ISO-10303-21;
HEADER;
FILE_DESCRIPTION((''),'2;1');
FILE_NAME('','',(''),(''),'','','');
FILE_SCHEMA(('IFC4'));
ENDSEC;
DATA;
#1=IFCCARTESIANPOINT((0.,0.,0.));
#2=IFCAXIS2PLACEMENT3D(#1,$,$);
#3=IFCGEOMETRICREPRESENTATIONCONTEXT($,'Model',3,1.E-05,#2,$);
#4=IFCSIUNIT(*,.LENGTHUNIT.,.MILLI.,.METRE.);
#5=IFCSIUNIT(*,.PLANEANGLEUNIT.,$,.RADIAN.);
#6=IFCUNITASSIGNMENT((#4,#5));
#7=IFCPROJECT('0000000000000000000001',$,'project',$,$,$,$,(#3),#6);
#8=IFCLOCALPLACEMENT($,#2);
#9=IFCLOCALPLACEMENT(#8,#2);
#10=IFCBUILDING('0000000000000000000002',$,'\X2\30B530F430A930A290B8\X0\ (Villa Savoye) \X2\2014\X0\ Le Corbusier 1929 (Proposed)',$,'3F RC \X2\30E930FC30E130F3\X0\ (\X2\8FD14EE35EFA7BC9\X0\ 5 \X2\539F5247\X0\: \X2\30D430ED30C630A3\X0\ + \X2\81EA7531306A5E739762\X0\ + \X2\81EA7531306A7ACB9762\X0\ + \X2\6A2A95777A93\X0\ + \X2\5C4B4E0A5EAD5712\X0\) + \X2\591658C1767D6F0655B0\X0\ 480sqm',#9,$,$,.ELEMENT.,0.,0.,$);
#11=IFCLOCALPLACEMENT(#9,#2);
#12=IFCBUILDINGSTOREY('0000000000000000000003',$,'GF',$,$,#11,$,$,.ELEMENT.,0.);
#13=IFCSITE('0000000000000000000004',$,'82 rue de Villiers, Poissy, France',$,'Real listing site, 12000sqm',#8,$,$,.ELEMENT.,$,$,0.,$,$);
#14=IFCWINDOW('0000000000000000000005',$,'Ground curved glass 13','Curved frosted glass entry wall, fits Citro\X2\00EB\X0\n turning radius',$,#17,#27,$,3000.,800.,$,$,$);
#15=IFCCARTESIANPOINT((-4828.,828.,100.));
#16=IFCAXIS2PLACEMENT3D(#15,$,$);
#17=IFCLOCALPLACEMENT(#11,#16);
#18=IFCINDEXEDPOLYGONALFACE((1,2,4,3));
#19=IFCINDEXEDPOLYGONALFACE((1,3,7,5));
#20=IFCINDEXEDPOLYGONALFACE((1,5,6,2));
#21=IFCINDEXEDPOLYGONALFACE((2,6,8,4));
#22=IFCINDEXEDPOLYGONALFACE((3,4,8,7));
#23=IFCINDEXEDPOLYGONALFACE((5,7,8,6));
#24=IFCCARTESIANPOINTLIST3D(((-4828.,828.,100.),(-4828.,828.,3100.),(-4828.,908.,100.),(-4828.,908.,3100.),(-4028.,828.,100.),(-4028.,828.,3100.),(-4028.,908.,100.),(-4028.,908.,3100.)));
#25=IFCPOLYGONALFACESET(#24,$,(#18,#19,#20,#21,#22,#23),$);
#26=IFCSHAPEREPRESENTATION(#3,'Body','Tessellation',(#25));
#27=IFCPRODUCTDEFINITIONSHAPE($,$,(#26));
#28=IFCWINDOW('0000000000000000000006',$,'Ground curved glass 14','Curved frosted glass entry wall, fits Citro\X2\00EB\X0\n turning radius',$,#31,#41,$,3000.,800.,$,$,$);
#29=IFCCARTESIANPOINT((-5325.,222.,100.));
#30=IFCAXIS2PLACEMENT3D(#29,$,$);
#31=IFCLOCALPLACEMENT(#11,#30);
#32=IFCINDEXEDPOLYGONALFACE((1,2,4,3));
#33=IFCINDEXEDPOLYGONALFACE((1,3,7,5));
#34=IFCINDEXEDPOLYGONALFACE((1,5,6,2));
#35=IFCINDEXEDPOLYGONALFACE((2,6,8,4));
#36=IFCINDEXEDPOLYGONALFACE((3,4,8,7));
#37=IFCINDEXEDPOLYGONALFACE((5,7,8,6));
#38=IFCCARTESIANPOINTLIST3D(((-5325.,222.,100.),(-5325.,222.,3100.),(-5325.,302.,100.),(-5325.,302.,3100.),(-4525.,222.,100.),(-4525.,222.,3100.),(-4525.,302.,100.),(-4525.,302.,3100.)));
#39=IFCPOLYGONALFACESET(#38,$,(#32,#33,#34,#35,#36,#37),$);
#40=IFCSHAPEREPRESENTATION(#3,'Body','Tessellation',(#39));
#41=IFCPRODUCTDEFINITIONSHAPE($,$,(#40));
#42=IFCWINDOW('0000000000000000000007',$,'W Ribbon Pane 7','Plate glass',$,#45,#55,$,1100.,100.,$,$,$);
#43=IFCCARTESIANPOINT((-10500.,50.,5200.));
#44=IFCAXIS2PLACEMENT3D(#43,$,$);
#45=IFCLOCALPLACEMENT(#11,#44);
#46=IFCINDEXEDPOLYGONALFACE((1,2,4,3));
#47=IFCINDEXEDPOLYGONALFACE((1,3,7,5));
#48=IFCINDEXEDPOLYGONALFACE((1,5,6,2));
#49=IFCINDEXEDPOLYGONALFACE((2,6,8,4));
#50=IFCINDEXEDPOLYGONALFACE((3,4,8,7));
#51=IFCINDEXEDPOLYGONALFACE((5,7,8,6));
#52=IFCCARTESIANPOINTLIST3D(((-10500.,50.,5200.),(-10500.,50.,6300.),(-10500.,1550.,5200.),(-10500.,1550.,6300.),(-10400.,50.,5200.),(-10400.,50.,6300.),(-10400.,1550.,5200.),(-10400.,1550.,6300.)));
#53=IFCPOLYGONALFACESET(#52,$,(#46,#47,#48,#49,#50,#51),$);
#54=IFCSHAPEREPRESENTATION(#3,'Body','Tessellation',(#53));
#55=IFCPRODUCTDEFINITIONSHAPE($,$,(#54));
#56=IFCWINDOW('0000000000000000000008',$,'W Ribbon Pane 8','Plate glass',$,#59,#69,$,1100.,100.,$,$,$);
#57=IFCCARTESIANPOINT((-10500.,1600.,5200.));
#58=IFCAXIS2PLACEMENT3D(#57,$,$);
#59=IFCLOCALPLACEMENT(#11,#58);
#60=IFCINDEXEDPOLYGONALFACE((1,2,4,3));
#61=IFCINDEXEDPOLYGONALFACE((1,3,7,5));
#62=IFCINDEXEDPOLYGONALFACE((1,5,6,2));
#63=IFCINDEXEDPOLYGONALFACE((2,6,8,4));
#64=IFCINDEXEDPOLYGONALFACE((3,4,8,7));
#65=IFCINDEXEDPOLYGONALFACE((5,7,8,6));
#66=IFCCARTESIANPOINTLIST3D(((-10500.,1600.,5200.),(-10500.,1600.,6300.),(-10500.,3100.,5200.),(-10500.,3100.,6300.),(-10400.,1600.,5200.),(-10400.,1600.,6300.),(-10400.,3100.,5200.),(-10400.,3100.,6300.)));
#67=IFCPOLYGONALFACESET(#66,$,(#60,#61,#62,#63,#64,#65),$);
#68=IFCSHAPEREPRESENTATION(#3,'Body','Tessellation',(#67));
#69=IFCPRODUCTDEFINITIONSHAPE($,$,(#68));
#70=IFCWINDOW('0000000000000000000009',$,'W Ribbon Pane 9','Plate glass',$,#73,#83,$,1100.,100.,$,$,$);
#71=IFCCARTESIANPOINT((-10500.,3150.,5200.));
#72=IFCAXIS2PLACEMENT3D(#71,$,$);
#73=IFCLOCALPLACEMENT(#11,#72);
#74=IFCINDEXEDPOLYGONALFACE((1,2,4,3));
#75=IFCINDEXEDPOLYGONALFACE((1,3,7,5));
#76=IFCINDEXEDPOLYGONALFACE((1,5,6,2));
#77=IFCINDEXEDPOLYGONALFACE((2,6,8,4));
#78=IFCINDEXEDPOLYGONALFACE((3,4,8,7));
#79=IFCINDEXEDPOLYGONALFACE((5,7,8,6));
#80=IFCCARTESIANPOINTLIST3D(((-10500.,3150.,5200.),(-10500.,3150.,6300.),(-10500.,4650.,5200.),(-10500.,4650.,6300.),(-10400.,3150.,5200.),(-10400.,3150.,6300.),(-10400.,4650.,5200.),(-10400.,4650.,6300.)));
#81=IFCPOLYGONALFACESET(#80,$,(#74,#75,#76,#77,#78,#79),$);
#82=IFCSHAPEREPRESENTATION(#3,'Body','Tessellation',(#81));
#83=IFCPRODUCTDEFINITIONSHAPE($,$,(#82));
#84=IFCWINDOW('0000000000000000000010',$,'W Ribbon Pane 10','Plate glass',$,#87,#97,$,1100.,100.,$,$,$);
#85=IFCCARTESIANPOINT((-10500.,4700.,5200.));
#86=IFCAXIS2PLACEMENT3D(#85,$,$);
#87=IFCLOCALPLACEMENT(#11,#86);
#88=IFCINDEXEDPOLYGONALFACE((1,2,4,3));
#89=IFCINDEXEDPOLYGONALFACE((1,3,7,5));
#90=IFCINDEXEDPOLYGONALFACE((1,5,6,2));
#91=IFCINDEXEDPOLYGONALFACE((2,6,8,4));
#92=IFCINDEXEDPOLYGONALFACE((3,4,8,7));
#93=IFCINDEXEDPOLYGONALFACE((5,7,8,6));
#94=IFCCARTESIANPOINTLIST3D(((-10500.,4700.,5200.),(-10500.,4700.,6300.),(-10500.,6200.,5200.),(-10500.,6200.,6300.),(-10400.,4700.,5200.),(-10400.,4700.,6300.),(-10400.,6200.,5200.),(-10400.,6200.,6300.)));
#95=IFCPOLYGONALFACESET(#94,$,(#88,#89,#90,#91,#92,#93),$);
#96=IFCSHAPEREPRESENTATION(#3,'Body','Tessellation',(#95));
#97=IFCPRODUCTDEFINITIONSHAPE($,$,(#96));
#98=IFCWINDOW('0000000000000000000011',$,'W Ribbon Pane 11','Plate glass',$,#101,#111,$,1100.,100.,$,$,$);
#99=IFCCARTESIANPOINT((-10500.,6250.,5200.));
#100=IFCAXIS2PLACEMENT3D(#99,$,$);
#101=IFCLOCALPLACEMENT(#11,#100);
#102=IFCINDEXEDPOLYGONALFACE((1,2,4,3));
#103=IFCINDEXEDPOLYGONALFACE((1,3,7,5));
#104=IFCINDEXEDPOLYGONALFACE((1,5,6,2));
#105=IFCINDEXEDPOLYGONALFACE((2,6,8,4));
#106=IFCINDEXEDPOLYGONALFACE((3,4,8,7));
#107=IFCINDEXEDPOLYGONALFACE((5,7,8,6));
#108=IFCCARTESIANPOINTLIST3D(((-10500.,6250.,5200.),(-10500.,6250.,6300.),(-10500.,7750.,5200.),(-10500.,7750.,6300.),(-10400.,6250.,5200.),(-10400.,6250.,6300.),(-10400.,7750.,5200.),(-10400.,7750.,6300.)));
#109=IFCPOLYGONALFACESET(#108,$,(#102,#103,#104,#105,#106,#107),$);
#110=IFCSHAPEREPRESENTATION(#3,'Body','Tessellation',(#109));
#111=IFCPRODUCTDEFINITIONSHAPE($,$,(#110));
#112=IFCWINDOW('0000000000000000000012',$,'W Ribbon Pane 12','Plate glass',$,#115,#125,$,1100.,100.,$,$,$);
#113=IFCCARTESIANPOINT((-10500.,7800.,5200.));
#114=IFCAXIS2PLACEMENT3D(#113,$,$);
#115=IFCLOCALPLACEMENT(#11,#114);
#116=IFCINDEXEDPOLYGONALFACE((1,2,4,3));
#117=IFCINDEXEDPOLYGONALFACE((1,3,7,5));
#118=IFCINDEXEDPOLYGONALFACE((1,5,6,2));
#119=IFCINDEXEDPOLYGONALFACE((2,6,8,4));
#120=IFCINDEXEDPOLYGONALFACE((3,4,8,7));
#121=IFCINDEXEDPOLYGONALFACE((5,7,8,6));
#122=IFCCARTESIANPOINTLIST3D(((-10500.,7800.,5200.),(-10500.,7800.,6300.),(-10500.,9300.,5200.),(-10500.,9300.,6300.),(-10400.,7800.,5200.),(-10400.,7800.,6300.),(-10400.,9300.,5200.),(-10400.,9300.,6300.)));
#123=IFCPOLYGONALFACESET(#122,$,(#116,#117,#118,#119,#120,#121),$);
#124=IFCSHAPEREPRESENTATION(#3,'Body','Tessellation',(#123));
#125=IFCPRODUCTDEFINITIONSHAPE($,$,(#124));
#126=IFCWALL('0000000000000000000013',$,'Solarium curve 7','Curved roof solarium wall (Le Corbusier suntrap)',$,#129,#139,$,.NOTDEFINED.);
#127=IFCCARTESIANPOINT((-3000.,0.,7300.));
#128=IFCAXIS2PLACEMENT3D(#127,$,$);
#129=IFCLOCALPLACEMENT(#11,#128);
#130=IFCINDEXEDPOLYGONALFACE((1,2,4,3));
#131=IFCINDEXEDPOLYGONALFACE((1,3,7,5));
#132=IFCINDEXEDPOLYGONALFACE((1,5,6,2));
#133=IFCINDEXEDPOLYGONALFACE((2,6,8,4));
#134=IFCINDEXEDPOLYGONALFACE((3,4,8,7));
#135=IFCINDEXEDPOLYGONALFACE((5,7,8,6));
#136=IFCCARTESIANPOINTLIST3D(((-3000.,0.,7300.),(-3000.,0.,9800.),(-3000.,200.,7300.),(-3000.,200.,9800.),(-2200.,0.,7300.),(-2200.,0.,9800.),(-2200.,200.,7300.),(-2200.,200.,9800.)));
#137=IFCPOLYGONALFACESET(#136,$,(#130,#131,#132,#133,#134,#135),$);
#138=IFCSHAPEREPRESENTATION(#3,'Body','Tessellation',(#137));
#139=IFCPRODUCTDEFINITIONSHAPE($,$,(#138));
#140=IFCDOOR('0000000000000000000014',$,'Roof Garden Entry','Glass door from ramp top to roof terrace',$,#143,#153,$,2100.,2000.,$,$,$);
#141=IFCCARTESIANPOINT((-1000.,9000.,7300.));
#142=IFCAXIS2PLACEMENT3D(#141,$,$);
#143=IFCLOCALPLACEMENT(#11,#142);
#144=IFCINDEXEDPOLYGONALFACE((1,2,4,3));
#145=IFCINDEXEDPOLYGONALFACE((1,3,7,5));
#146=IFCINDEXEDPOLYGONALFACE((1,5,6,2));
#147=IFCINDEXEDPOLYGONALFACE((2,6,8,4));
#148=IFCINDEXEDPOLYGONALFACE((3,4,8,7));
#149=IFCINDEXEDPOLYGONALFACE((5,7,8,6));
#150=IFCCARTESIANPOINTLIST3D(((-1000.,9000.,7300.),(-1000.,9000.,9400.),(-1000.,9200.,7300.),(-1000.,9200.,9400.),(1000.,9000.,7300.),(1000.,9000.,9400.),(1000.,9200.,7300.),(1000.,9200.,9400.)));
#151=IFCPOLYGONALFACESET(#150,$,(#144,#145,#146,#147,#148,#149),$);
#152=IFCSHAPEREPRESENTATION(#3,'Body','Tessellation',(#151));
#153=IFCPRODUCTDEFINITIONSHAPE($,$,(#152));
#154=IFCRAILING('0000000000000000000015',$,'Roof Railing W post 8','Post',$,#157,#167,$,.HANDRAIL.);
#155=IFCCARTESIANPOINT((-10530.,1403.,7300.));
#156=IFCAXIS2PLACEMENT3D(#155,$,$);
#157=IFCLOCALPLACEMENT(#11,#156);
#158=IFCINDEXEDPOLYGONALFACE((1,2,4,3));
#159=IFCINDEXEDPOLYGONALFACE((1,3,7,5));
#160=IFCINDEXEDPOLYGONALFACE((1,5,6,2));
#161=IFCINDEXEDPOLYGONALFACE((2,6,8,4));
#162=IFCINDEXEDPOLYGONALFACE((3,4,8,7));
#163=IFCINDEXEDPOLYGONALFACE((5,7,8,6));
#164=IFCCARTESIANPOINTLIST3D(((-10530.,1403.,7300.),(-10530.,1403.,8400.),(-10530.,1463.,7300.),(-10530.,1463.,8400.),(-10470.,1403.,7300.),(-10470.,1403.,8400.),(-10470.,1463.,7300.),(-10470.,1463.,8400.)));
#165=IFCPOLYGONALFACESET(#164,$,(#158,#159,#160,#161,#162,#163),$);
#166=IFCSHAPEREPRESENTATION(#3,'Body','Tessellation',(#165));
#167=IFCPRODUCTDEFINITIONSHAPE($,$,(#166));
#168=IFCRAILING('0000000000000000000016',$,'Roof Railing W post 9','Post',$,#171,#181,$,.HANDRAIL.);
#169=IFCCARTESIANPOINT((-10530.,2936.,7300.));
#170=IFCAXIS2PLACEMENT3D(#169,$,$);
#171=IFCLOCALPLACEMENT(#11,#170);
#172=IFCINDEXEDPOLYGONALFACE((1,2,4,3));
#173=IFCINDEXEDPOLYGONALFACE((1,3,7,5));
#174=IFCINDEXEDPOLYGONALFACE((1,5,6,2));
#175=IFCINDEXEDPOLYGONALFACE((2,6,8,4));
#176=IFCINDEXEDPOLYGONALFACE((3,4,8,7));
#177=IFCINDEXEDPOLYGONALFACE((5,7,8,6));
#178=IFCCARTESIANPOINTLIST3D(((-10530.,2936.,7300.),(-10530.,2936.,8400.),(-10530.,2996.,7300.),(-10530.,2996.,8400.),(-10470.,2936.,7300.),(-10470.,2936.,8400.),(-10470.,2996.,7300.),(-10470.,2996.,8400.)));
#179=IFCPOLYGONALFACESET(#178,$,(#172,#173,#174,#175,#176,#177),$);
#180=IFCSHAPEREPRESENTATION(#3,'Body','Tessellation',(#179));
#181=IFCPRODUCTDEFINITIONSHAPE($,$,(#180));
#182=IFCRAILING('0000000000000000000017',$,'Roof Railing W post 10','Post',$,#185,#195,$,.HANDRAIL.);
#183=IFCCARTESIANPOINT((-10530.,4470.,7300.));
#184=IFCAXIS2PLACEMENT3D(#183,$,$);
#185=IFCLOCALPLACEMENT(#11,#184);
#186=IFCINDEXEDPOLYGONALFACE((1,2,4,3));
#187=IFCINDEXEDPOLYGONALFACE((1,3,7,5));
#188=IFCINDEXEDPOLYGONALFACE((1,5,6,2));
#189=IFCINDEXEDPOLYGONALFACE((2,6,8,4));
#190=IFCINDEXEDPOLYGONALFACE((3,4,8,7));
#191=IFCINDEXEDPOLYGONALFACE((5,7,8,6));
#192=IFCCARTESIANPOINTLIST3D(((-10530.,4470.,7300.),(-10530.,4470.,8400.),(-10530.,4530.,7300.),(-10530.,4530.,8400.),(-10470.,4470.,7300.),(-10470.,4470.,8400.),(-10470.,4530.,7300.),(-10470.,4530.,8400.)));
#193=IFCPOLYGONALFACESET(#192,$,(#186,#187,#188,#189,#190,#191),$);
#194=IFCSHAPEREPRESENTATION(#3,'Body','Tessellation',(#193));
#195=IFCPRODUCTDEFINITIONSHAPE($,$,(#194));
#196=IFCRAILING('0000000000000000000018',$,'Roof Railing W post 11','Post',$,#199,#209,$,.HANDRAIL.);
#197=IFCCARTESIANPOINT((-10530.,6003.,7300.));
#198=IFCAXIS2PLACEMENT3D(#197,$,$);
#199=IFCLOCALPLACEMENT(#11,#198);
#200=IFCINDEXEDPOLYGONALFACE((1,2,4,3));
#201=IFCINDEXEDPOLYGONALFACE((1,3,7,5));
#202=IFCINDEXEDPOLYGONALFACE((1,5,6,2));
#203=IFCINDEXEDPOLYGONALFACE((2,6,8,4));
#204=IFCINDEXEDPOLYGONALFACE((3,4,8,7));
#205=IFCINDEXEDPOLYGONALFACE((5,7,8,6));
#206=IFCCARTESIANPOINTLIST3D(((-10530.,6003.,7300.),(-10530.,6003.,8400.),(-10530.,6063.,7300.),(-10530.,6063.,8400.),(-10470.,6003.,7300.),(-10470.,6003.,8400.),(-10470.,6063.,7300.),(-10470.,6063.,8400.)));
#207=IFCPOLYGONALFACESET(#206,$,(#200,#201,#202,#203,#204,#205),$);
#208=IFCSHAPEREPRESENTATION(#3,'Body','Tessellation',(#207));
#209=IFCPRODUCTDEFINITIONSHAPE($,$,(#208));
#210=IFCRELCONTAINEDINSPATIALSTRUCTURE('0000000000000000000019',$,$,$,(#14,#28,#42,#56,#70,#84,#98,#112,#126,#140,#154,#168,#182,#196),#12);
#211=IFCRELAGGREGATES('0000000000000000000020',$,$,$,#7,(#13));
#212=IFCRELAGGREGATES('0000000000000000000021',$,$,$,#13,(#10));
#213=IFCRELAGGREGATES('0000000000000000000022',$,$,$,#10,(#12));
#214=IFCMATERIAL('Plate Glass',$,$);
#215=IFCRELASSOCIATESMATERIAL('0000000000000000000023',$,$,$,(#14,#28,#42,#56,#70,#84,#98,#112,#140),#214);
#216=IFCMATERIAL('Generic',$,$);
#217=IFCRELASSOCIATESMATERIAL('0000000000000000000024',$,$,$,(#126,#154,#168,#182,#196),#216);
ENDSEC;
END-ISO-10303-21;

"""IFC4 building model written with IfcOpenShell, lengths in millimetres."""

from ifc_helpers import new_model, si_unit, frame, frame_2d, origin, place, context, project, spatial, rectangle, extrude, material, element, save


model = new_model("IFC4")

# Units and contexts
model_context = context("Model", 3, precision=1e-05, world=origin())
ifc_project = project(units=[si_unit("LENGTHUNIT", "METRE", prefix="MILLI"), si_unit("PLANEANGLEUNIT", "RADIAN")], contexts=[model_context])

# Site, building, storey
site_placement = place(None, origin())
site = spatial("IfcSite", under=ifc_project, at=site_placement, Name="82 rue de Villiers, Poissy, France", ObjectType="Real listing site, 12000sqm", CompositionType="ELEMENT", RefElevation=0.0)
building_placement = place(site_placement, origin())
building = spatial("IfcBuilding", under=site, at=building_placement, Name="サヴォア邸 (Villa Savoye) — Le Corbusier 1929 (Proposed)", ObjectType="3F RC ラーメン (近代建築 5 原則: ピロティ + 自由な平面 + 自由な立面 + 横長窓 + 屋上庭園) + 外壁白漆喰 480sqm", CompositionType="ELEMENT", ElevationOfRefHeight=0.0, ElevationOfTerrain=0.0)
storey_placement = place(building_placement, origin())
storey = spatial("IfcBuildingStorey", under=building, at=storey_placement, Name="GF", CompositionType="ELEMENT", Elevation=0.0)

# Shared definitions
ifc_material_1 = material(Name="Generic")

# Windows
ifc_material_2 = material(Name="Plate Glass")
window_1_placement = place(storey_placement, frame((-4828.0, 828.0, 100.0)))
element("IfcWindow", 1, at=window_1_placement, inside=storey, material=ifc_material_2, Name="Ground curved glass 13", Description="Curved frosted glass entry wall, fits Citroën turning radius", OverallHeight=3000.0, OverallWidth=800.0, context=model_context, shape_type="SweptSolid", body=[
    extrude(rectangle(XDim=800.0, YDim=80.0, at=frame_2d((400.0, 40.0))), frame((-4828.0, 828.0, 100.0)), (0.0, 0.0, 1.0), 3000.0),
])
window_2_placement = place(storey_placement, frame((-5325.0, 222.0, 100.0)))
element("IfcWindow", 2, at=window_2_placement, inside=storey, material=ifc_material_2, Name="Ground curved glass 14", Description="Curved frosted glass entry wall, fits Citroën turning radius", OverallHeight=3000.0, OverallWidth=800.0, context=model_context, shape_type="SweptSolid", body=[
    extrude(rectangle(XDim=800.0, YDim=80.0, at=frame_2d((400.0, 40.0))), frame((-5325.0, 222.0, 100.0)), (0.0, 0.0, 1.0), 3000.0),
])
window_3_placement = place(storey_placement, frame((-10500.0, 50.0, 5200.0)))
element("IfcWindow", 3, at=window_3_placement, inside=storey, material=ifc_material_2, Name="W Ribbon Pane 7", Description="Plate glass", OverallHeight=1100.0, OverallWidth=100.0, context=model_context, shape_type="SweptSolid", body=[
    extrude(rectangle(XDim=100.0, YDim=1500.0, at=frame_2d((50.0, 750.0))), frame((-10500.0, 50.0, 5200.0)), (0.0, 0.0, 1.0), 1100.0),
])
window_4_placement = place(storey_placement, frame((-10500.0, 1600.0, 5200.0)))
element("IfcWindow", 4, at=window_4_placement, inside=storey, material=ifc_material_2, Name="W Ribbon Pane 8", Description="Plate glass", OverallHeight=1100.0, OverallWidth=100.0, context=model_context, shape_type="SweptSolid", body=[
    extrude(rectangle(XDim=100.0, YDim=1500.0, at=frame_2d((50.0, 750.0))), frame((-10500.0, 1600.0, 5200.0)), (0.0, 0.0, 1.0), 1100.0),
])
window_5_placement = place(storey_placement, frame((-10500.0, 3150.0, 5200.0)))
element("IfcWindow", 5, at=window_5_placement, inside=storey, material=ifc_material_2, Name="W Ribbon Pane 9", Description="Plate glass", OverallHeight=1100.0, OverallWidth=100.0, context=model_context, shape_type="SweptSolid", body=[
    extrude(rectangle(XDim=100.0, YDim=1500.0, at=frame_2d((50.0, 750.0))), frame((-10500.0, 3150.0, 5200.0)), (0.0, 0.0, 1.0), 1100.0),
])
window_6_placement = place(storey_placement, frame((-10500.0, 4700.0, 5200.0)))
element("IfcWindow", 6, at=window_6_placement, inside=storey, material=ifc_material_2, Name="W Ribbon Pane 10", Description="Plate glass", OverallHeight=1100.0, OverallWidth=100.0, context=model_context, shape_type="SweptSolid", body=[
    extrude(rectangle(XDim=100.0, YDim=1500.0, at=frame_2d((50.0, 750.0))), frame((-10500.0, 4700.0, 5200.0)), (0.0, 0.0, 1.0), 1100.0),
])
window_7_placement = place(storey_placement, frame((-10500.0, 6250.0, 5200.0)))
element("IfcWindow", 7, at=window_7_placement, inside=storey, material=ifc_material_2, Name="W Ribbon Pane 11", Description="Plate glass", OverallHeight=1100.0, OverallWidth=100.0, context=model_context, shape_type="SweptSolid", body=[
    extrude(rectangle(XDim=100.0, YDim=1500.0, at=frame_2d((50.0, 750.0))), frame((-10500.0, 6250.0, 5200.0)), (0.0, 0.0, 1.0), 1100.0),
])
window_8_placement = place(storey_placement, frame((-10500.0, 7800.0, 5200.0)))
element("IfcWindow", 8, at=window_8_placement, inside=storey, material=ifc_material_2, Name="W Ribbon Pane 12", Description="Plate glass", OverallHeight=1100.0, OverallWidth=100.0, context=model_context, shape_type="SweptSolid", body=[
    extrude(rectangle(XDim=100.0, YDim=1500.0, at=frame_2d((50.0, 750.0))), frame((-10500.0, 7800.0, 5200.0)), (0.0, 0.0, 1.0), 1100.0),
])

# Wall
wall_placement = place(storey_placement, frame((-3000.0, 0.0, 7300.0)))
element("IfcWall", 9, at=wall_placement, inside=storey, material=ifc_material_1, Name="Solarium curve 7", Description="Curved roof solarium wall (Le Corbusier suntrap)", PredefinedType="NOTDEFINED", context=model_context, shape_type="SweptSolid", body=[
    extrude(rectangle(XDim=800.0, YDim=200.0, at=frame_2d((400.0, 100.0))), frame((-3000.0, 0.0, 7300.0)), (0.0, 0.0, 1.0), 2500.0),
])

# Door
door_placement = place(storey_placement, frame((-1000.0, 9000.0, 7300.0)))
element("IfcDoor", 10, at=door_placement, inside=storey, material=ifc_material_2, Name="Roof Garden Entry", Description="Glass door from ramp top to roof terrace", OverallHeight=2100.0, OverallWidth=2000.0, context=model_context, shape_type="SweptSolid", body=[
    extrude(rectangle(XDim=2000.0, YDim=200.0, at=frame_2d((1000.0, 100.0))), frame((-1000.0, 9000.0, 7300.0)), (0.0, 0.0, 1.0), 2100.0),
])

# Railings
railing_1_placement = place(storey_placement, frame((-10530.0, 1403.0, 7300.0)))
element("IfcRailing", 11, at=railing_1_placement, inside=storey, material=ifc_material_1, Name="Roof Railing W post 8", Description="Post", PredefinedType="HANDRAIL", context=model_context, shape_type="SweptSolid", body=[
    extrude(rectangle(XDim=60.0, YDim=60.0, at=frame_2d((30.0, 30.0))), frame((-10530.0, 1403.0, 7300.0)), (0.0, 0.0, 1.0), 1100.0),
])
railing_2_placement = place(storey_placement, frame((-10530.0, 2936.0, 7300.0)))
element("IfcRailing", 12, at=railing_2_placement, inside=storey, material=ifc_material_1, Name="Roof Railing W post 9", Description="Post", PredefinedType="HANDRAIL", context=model_context, shape_type="SweptSolid", body=[
    extrude(rectangle(XDim=60.0, YDim=60.0, at=frame_2d((30.0, 30.0))), frame((-10530.0, 2936.0, 7300.0)), (0.0, 0.0, 1.0), 1100.0),
])
railing_3_placement = place(storey_placement, frame((-10530.0, 4470.0, 7300.0)))
element("IfcRailing", 13, at=railing_3_placement, inside=storey, material=ifc_material_1, Name="Roof Railing W post 10", Description="Post", PredefinedType="HANDRAIL", context=model_context, shape_type="SweptSolid", body=[
    extrude(rectangle(XDim=60.0, YDim=60.0, at=frame_2d((30.0, 30.0))), frame((-10530.0, 4470.0, 7300.0)), (0.0, 0.0, 1.0), 1100.0),
])
railing_4_placement = place(storey_placement, frame((-10530.0, 6003.0, 7300.0)))
element("IfcRailing", 14, at=railing_4_placement, inside=storey, material=ifc_material_1, Name="Roof Railing W post 11", Description="Post", PredefinedType="HANDRAIL", context=model_context, shape_type="SweptSolid", body=[
    extrude(rectangle(XDim=60.0, YDim=60.0, at=frame_2d((30.0, 30.0))), frame((-10530.0, 6003.0, 7300.0)), (0.0, 0.0, 1.0), 1100.0),
])

save(model, "model.ifc")
